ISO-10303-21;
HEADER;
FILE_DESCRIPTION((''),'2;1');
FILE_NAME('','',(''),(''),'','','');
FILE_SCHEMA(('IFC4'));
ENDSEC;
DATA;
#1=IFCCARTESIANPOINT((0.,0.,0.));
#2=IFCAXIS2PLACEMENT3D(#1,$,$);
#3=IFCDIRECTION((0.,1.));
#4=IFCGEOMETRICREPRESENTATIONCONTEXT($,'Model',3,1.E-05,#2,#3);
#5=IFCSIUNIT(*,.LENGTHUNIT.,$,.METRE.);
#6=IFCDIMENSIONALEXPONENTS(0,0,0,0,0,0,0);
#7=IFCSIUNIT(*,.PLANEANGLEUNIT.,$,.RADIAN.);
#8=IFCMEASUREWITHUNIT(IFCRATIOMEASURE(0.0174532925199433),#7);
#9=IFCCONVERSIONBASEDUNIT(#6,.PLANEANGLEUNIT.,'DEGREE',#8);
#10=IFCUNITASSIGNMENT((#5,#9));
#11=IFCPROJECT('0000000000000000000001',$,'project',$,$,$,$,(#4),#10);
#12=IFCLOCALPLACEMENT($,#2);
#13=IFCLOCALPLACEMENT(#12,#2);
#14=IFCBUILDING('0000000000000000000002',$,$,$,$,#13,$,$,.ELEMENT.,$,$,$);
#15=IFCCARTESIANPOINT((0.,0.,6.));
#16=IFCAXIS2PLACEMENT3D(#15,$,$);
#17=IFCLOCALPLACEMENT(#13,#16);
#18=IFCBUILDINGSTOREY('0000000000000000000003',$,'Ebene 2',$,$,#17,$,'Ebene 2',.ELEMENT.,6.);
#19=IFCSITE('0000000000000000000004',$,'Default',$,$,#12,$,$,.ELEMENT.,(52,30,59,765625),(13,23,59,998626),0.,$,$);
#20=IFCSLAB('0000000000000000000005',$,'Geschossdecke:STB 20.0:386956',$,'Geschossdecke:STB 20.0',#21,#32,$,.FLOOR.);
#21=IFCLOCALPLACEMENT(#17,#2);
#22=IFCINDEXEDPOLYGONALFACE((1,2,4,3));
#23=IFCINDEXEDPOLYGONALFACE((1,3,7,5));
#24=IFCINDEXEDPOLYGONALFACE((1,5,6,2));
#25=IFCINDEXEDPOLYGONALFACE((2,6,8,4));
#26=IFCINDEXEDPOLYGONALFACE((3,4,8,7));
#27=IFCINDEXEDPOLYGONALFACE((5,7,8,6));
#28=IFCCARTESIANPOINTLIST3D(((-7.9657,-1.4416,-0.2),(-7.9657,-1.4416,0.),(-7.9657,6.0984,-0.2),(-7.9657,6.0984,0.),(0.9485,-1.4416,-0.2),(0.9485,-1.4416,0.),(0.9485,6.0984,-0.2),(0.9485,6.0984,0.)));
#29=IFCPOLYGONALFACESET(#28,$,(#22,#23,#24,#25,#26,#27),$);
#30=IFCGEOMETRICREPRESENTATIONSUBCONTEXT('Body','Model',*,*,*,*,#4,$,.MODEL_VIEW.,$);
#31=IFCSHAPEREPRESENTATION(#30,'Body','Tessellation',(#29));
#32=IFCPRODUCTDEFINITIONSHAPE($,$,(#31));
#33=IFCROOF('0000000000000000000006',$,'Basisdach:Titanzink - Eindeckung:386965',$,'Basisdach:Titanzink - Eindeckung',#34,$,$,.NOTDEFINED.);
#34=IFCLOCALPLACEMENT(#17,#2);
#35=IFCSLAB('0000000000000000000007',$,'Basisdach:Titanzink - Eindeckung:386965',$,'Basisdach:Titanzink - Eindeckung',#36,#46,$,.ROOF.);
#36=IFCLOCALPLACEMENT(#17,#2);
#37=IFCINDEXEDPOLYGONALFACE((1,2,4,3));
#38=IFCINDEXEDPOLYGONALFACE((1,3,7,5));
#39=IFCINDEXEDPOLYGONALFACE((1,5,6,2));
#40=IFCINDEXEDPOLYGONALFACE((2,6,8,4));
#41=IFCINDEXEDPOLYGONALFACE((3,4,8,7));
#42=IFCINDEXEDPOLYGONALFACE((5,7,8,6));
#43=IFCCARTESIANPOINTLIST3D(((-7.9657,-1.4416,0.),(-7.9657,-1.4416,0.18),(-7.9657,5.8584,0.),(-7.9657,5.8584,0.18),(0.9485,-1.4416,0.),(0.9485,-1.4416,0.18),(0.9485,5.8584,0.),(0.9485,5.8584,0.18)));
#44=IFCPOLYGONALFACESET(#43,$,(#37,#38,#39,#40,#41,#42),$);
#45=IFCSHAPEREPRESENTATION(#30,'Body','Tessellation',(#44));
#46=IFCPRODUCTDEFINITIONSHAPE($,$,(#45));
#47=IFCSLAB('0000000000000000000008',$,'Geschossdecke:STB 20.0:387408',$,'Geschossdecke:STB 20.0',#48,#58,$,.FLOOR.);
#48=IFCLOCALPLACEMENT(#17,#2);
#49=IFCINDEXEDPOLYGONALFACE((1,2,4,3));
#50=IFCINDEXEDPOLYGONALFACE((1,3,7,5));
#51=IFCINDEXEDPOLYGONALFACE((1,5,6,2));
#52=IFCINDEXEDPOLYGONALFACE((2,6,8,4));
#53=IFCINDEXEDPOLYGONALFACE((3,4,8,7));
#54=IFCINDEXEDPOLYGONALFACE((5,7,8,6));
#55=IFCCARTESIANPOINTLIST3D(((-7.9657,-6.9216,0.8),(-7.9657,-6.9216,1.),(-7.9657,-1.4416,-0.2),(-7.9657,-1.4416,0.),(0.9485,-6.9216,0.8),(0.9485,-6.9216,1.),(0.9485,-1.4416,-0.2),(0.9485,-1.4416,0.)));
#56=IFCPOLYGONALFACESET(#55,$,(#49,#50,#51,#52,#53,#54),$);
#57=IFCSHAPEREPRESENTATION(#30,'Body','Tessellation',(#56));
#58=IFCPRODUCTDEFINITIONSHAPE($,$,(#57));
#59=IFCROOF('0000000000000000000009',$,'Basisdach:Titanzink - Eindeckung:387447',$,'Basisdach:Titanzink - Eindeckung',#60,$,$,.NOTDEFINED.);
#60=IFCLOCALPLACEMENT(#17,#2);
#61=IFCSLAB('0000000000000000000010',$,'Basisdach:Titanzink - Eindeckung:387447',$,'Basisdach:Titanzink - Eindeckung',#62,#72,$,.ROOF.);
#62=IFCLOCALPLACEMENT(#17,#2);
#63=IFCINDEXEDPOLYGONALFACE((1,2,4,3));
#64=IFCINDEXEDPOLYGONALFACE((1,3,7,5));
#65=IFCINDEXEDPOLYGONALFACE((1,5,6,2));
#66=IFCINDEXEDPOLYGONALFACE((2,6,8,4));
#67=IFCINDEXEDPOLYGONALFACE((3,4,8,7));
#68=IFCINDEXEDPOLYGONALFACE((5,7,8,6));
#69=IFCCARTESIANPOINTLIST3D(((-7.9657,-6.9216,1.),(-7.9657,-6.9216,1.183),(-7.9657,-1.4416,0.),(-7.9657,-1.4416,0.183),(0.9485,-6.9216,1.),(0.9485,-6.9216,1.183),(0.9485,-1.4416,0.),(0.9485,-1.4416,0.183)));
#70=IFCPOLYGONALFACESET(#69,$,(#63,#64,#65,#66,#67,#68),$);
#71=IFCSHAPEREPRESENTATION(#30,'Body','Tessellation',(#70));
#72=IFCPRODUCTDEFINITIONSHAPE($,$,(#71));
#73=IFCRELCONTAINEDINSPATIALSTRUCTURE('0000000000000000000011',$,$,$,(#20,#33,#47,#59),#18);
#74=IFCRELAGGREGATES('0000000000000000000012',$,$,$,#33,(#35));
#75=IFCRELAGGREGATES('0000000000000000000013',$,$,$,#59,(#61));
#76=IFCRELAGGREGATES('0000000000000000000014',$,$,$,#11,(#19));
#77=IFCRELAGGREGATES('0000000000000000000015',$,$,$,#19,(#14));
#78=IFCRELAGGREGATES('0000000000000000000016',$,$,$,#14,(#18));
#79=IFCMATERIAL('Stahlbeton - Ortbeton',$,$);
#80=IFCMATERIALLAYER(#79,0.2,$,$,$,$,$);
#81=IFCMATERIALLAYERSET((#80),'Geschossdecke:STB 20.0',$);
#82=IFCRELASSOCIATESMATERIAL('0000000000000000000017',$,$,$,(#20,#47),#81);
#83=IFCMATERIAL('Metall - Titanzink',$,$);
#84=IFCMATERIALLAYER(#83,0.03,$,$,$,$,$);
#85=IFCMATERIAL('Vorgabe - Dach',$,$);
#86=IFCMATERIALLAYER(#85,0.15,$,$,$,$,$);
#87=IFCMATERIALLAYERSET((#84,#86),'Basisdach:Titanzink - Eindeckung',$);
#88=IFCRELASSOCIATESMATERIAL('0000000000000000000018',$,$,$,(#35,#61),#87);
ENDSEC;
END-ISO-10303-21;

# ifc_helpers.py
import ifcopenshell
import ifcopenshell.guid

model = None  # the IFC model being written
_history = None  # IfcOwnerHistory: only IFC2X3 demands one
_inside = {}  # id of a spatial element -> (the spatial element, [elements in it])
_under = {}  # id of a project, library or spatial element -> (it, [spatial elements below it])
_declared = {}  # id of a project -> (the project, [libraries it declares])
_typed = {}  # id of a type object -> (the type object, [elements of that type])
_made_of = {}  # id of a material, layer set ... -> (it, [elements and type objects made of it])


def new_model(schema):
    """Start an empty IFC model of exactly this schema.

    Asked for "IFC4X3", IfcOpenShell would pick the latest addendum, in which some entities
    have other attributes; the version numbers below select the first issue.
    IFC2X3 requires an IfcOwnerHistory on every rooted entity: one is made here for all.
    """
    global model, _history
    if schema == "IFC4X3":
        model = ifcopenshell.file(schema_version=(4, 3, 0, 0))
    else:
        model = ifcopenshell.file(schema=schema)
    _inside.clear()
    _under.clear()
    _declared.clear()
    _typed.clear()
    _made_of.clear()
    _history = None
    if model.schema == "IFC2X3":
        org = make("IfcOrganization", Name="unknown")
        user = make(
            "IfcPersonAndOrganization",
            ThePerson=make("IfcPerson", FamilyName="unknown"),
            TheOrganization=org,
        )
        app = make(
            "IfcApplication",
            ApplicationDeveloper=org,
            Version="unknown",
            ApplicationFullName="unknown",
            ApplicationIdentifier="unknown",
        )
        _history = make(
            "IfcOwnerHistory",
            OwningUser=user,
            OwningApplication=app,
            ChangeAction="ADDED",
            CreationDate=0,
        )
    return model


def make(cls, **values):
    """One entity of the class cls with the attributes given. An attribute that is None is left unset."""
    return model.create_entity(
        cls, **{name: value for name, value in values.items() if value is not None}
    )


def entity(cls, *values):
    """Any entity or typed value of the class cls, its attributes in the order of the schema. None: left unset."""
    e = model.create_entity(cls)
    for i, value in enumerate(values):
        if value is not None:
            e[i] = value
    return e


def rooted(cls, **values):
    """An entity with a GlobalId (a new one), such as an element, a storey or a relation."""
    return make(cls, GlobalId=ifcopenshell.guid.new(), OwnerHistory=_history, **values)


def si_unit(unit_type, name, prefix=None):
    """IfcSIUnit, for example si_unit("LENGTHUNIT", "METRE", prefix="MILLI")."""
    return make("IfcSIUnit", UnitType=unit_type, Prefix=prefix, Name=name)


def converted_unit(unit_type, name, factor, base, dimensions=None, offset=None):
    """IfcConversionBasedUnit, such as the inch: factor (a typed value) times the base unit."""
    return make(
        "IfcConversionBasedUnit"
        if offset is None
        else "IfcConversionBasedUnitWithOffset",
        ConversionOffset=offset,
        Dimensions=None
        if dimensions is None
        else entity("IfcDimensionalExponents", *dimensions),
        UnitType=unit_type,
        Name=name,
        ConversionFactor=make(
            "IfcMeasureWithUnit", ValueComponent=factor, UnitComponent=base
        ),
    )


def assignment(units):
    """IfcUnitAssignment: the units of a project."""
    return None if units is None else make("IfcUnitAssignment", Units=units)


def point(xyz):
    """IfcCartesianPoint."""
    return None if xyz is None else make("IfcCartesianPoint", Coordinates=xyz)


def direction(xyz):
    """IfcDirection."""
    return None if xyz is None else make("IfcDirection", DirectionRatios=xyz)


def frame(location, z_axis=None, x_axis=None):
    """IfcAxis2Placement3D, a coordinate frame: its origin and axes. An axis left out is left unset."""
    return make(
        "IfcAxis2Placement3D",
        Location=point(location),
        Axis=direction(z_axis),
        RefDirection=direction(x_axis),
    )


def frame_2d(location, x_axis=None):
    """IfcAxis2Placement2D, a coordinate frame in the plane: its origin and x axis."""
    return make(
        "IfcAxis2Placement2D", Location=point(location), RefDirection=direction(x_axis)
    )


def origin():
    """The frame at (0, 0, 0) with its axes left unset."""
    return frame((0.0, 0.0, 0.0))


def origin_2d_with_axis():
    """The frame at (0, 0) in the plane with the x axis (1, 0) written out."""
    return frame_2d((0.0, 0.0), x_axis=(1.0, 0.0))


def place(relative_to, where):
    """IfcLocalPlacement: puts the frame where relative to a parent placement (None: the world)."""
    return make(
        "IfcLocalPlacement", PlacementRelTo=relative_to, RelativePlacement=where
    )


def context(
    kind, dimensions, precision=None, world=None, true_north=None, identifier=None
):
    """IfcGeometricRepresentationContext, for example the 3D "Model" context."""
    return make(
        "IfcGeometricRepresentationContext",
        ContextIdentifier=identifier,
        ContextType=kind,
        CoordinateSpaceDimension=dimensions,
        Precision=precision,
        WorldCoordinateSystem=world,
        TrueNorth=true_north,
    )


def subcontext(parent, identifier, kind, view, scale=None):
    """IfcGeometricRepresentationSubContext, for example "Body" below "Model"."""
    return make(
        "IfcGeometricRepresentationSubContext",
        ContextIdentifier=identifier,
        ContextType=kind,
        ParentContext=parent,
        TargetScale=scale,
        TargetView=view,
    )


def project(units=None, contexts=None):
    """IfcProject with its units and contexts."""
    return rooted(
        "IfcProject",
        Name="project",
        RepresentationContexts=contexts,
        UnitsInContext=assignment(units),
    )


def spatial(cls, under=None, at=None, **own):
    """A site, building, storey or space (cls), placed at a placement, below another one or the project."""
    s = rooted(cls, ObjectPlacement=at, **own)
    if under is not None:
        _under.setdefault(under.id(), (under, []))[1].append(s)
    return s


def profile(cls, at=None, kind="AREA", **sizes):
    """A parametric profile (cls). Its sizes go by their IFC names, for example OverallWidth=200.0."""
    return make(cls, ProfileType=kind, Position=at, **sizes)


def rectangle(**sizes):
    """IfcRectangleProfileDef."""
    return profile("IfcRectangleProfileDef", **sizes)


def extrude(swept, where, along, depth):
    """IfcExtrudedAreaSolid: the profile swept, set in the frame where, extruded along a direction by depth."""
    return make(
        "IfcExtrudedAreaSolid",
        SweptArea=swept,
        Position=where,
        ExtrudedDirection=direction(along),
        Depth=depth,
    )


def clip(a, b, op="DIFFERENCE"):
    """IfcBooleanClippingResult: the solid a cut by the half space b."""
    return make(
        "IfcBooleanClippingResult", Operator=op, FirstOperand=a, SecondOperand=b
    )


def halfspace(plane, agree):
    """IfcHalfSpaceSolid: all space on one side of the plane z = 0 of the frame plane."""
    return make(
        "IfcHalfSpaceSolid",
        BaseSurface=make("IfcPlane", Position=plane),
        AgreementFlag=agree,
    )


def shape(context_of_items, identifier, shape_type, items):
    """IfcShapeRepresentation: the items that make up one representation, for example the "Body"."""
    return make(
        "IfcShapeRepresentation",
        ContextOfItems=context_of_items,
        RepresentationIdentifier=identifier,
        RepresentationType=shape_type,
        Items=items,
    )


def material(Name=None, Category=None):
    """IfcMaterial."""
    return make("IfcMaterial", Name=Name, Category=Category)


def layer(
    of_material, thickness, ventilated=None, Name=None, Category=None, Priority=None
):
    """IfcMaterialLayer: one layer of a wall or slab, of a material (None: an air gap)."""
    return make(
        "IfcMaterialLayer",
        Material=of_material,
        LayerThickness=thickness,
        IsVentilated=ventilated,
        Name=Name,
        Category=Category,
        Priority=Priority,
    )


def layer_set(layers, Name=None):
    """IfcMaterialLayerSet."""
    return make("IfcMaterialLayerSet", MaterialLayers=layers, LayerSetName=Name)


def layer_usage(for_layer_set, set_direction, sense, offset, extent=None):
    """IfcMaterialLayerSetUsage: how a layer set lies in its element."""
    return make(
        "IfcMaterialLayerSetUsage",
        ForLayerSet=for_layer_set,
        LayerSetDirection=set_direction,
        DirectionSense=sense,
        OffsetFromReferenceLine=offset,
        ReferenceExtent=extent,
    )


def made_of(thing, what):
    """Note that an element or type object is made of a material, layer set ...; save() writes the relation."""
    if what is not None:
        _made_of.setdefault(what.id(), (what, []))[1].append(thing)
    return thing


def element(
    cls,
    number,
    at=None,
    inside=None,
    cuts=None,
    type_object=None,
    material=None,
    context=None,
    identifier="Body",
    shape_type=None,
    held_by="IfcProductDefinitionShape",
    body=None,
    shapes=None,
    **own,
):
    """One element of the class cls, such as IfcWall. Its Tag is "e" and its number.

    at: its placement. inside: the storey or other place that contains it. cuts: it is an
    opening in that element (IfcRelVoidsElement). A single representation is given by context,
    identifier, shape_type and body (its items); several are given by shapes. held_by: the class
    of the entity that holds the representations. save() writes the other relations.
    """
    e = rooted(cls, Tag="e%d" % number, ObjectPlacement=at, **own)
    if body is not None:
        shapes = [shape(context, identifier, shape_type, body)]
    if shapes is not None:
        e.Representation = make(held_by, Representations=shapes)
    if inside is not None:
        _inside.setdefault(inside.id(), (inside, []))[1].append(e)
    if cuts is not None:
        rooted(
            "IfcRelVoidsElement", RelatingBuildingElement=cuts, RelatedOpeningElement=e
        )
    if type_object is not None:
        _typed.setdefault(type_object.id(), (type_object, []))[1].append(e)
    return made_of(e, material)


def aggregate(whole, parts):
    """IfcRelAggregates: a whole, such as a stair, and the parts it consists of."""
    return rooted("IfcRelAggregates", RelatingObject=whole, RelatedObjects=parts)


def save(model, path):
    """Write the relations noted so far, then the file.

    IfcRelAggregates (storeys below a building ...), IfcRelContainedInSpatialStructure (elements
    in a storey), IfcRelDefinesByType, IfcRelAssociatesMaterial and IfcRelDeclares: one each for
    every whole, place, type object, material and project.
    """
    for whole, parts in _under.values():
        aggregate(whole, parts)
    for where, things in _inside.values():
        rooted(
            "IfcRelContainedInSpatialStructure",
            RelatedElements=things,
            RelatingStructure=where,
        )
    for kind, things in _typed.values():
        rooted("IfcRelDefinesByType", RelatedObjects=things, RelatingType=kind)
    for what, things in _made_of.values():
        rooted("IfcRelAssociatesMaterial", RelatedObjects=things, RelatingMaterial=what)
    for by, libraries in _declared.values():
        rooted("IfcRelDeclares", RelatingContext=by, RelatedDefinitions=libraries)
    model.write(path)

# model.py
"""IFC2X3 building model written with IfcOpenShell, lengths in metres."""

from ifc_helpers import new_model, entity, si_unit, converted_unit, direction, frame, frame_2d, origin, origin_2d_with_axis, place, context, subcontext, project, spatial, rectangle, extrude, clip, halfspace, material, layer, layer_set, layer_usage, element, aggregate, save


model = new_model("IFC2X3")

# Units and contexts
model_context = context("Model", 3, precision=1e-05, world=origin(), true_north=direction((0.0, 1.0)))
body_context = subcontext(model_context, "Body", "Model", "MODEL_VIEW")
ifc_project = project(units=[si_unit("LENGTHUNIT", "METRE"), converted_unit("PLANEANGLEUNIT", "DEGREE", entity("IfcRatioMeasure", 0.0174532925199433), si_unit("PLANEANGLEUNIT", "RADIAN"), dimensions=[0, 0, 0, 0, 0, 0, 0])], contexts=[model_context])

# Site, building, storey
site_placement = place(None, origin())
site = spatial("IfcSite", under=ifc_project, at=site_placement, Name="Default", CompositionType="ELEMENT", RefLatitude=(52, 30, 59, 765625), RefLongitude=(13, 23, 59, 998626), RefElevation=0.0)
building_placement = place(site_placement, origin())
building = spatial("IfcBuilding", under=site, at=building_placement, CompositionType="ELEMENT")
storey_placement = place(building_placement, frame((0.0, 0.0, 6.0)))
storey = spatial("IfcBuildingStorey", under=building, at=storey_placement, Name="Ebene 2", LongName="Ebene 2", CompositionType="ELEMENT", Elevation=6.0)

# Slab
ifc_material_1 = material(Name="Stahlbeton - Ortbeton")
ifc_layer_1 = layer(ifc_material_1, 0.2)
ifc_layer_set_1 = layer_set([ifc_layer_1], Name="Geschossdecke:STB 20.0")
ifc_layer_usage_1 = layer_usage(ifc_layer_set_1, "AXIS3", "POSITIVE", 0.0)
slab_1_placement = place(storey_placement, origin())
element("IfcSlab", 1, at=slab_1_placement, inside=storey, material=ifc_layer_usage_1, Name="Geschossdecke:STB 20.0:386956", ObjectType="Geschossdecke:STB 20.0", PredefinedType="FLOOR", context=body_context, shape_type="SweptSolid", body=[
    extrude(rectangle(XDim=7.54, YDim=8.9141, at=frame_2d((0.0, 0.0), x_axis=(1.0, 0.0))), frame((-3.5086, 2.3284, 0.0), z_axis=(0.0, 0.0, -1.0), x_axis=(0.0, 1.0, 0.0)), (0.0, 0.0, 1.0), 0.2),
])

# Roof, slab
roof_1_placement = place(storey_placement, frame((-7.9657, -1.4416, 0.0)))
roof_1 = element("IfcRoof", 2, at=roof_1_placement, inside=storey, Name="Basisdach:Titanzink - Eindeckung:386965", ObjectType="Basisdach:Titanzink - Eindeckung", ShapeType="NOTDEFINED")
ifc_material_2 = material(Name="Metall - Titanzink")
ifc_layer_2 = layer(ifc_material_2, 0.03)
ifc_material_3 = material(Name="Vorgabe - Dach")
ifc_layer_3 = layer(ifc_material_3, 0.15)
ifc_layer_set_2 = layer_set([ifc_layer_2, ifc_layer_3], Name="Basisdach:Titanzink - Eindeckung")
slab_2_placement = place(roof_1_placement, origin())
slab_2 = element("IfcSlab", 3, at=slab_2_placement, material=ifc_layer_set_2, Name="Basisdach:Titanzink - Eindeckung:386965", ObjectType="Basisdach:Titanzink - Eindeckung", PredefinedType="ROOF", context=body_context, shape_type="SweptSolid", body=[
    extrude(rectangle(XDim=7.3, YDim=8.9141, at=frame_2d((0.0, 0.0), x_axis=(0.0, 1.0))), frame((4.4571, 3.65, 0.0)), (0.0, 0.0, 1.0), 0.18),
])
aggregate(roof_1, [slab_2])

# Slab
ifc_layer_usage_2 = layer_usage(ifc_layer_set_1, "AXIS3", "POSITIVE", 0.0)
slab_3_placement = place(storey_placement, origin())
element("IfcSlab", 4, at=slab_3_placement, inside=storey, material=ifc_layer_usage_2, Name="Geschossdecke:STB 20.0:387408", ObjectType="Geschossdecke:STB 20.0", PredefinedType="FLOOR", context=body_context, shape_type="Clipping", body=[
    clip(clip(extrude(rectangle(XDim=5.5705, YDim=8.9141, at=origin_2d_with_axis()), frame((-3.5086, -4.1816, 0.5), z_axis=(0.0, -0.179517, -0.983755), x_axis=(0.0, 0.983755, -0.179517)), (0.179517, 0.0, 0.983755), 0.2033), halfspace(frame((-3.5086, -4.1816, 0.5), z_axis=(0.0, 0.179517, 0.983755), x_axis=(1.0, 0.0, 0.0)), False)), halfspace(frame((-3.5086, -4.1816, 0.3), z_axis=(0.0, -0.179517, -0.983755), x_axis=(1.0, 0.0, 0.0)), False)),
])

# Roof, slab
roof_2_placement = place(storey_placement, frame((-7.9657, -6.9216, 0.0)))
roof_2 = element("IfcRoof", 5, at=roof_2_placement, inside=storey, Name="Basisdach:Titanzink - Eindeckung:387447", ObjectType="Basisdach:Titanzink - Eindeckung", ShapeType="NOTDEFINED")
slab_4_placement = place(roof_2_placement, origin())
slab_4 = element("IfcSlab", 6, at=slab_4_placement, material=ifc_layer_set_2, Name="Basisdach:Titanzink - Eindeckung:387447", ObjectType="Basisdach:Titanzink - Eindeckung", PredefinedType="ROOF", context=body_context, shape_type="SweptSolid", body=[
    extrude(rectangle(XDim=8.9141, YDim=5.5705, at=frame_2d((0.0, 0.0), x_axis=(1.0, 0.0))), frame((4.4571, 2.74, 0.5), z_axis=(0.0, 0.179517, 0.983755), x_axis=(1.0, 0.0, 0.0)), (0.0, -0.179517, 0.983755), 0.183),
])
aggregate(roof_2, [slab_4])

save(model, "model.ifc")
